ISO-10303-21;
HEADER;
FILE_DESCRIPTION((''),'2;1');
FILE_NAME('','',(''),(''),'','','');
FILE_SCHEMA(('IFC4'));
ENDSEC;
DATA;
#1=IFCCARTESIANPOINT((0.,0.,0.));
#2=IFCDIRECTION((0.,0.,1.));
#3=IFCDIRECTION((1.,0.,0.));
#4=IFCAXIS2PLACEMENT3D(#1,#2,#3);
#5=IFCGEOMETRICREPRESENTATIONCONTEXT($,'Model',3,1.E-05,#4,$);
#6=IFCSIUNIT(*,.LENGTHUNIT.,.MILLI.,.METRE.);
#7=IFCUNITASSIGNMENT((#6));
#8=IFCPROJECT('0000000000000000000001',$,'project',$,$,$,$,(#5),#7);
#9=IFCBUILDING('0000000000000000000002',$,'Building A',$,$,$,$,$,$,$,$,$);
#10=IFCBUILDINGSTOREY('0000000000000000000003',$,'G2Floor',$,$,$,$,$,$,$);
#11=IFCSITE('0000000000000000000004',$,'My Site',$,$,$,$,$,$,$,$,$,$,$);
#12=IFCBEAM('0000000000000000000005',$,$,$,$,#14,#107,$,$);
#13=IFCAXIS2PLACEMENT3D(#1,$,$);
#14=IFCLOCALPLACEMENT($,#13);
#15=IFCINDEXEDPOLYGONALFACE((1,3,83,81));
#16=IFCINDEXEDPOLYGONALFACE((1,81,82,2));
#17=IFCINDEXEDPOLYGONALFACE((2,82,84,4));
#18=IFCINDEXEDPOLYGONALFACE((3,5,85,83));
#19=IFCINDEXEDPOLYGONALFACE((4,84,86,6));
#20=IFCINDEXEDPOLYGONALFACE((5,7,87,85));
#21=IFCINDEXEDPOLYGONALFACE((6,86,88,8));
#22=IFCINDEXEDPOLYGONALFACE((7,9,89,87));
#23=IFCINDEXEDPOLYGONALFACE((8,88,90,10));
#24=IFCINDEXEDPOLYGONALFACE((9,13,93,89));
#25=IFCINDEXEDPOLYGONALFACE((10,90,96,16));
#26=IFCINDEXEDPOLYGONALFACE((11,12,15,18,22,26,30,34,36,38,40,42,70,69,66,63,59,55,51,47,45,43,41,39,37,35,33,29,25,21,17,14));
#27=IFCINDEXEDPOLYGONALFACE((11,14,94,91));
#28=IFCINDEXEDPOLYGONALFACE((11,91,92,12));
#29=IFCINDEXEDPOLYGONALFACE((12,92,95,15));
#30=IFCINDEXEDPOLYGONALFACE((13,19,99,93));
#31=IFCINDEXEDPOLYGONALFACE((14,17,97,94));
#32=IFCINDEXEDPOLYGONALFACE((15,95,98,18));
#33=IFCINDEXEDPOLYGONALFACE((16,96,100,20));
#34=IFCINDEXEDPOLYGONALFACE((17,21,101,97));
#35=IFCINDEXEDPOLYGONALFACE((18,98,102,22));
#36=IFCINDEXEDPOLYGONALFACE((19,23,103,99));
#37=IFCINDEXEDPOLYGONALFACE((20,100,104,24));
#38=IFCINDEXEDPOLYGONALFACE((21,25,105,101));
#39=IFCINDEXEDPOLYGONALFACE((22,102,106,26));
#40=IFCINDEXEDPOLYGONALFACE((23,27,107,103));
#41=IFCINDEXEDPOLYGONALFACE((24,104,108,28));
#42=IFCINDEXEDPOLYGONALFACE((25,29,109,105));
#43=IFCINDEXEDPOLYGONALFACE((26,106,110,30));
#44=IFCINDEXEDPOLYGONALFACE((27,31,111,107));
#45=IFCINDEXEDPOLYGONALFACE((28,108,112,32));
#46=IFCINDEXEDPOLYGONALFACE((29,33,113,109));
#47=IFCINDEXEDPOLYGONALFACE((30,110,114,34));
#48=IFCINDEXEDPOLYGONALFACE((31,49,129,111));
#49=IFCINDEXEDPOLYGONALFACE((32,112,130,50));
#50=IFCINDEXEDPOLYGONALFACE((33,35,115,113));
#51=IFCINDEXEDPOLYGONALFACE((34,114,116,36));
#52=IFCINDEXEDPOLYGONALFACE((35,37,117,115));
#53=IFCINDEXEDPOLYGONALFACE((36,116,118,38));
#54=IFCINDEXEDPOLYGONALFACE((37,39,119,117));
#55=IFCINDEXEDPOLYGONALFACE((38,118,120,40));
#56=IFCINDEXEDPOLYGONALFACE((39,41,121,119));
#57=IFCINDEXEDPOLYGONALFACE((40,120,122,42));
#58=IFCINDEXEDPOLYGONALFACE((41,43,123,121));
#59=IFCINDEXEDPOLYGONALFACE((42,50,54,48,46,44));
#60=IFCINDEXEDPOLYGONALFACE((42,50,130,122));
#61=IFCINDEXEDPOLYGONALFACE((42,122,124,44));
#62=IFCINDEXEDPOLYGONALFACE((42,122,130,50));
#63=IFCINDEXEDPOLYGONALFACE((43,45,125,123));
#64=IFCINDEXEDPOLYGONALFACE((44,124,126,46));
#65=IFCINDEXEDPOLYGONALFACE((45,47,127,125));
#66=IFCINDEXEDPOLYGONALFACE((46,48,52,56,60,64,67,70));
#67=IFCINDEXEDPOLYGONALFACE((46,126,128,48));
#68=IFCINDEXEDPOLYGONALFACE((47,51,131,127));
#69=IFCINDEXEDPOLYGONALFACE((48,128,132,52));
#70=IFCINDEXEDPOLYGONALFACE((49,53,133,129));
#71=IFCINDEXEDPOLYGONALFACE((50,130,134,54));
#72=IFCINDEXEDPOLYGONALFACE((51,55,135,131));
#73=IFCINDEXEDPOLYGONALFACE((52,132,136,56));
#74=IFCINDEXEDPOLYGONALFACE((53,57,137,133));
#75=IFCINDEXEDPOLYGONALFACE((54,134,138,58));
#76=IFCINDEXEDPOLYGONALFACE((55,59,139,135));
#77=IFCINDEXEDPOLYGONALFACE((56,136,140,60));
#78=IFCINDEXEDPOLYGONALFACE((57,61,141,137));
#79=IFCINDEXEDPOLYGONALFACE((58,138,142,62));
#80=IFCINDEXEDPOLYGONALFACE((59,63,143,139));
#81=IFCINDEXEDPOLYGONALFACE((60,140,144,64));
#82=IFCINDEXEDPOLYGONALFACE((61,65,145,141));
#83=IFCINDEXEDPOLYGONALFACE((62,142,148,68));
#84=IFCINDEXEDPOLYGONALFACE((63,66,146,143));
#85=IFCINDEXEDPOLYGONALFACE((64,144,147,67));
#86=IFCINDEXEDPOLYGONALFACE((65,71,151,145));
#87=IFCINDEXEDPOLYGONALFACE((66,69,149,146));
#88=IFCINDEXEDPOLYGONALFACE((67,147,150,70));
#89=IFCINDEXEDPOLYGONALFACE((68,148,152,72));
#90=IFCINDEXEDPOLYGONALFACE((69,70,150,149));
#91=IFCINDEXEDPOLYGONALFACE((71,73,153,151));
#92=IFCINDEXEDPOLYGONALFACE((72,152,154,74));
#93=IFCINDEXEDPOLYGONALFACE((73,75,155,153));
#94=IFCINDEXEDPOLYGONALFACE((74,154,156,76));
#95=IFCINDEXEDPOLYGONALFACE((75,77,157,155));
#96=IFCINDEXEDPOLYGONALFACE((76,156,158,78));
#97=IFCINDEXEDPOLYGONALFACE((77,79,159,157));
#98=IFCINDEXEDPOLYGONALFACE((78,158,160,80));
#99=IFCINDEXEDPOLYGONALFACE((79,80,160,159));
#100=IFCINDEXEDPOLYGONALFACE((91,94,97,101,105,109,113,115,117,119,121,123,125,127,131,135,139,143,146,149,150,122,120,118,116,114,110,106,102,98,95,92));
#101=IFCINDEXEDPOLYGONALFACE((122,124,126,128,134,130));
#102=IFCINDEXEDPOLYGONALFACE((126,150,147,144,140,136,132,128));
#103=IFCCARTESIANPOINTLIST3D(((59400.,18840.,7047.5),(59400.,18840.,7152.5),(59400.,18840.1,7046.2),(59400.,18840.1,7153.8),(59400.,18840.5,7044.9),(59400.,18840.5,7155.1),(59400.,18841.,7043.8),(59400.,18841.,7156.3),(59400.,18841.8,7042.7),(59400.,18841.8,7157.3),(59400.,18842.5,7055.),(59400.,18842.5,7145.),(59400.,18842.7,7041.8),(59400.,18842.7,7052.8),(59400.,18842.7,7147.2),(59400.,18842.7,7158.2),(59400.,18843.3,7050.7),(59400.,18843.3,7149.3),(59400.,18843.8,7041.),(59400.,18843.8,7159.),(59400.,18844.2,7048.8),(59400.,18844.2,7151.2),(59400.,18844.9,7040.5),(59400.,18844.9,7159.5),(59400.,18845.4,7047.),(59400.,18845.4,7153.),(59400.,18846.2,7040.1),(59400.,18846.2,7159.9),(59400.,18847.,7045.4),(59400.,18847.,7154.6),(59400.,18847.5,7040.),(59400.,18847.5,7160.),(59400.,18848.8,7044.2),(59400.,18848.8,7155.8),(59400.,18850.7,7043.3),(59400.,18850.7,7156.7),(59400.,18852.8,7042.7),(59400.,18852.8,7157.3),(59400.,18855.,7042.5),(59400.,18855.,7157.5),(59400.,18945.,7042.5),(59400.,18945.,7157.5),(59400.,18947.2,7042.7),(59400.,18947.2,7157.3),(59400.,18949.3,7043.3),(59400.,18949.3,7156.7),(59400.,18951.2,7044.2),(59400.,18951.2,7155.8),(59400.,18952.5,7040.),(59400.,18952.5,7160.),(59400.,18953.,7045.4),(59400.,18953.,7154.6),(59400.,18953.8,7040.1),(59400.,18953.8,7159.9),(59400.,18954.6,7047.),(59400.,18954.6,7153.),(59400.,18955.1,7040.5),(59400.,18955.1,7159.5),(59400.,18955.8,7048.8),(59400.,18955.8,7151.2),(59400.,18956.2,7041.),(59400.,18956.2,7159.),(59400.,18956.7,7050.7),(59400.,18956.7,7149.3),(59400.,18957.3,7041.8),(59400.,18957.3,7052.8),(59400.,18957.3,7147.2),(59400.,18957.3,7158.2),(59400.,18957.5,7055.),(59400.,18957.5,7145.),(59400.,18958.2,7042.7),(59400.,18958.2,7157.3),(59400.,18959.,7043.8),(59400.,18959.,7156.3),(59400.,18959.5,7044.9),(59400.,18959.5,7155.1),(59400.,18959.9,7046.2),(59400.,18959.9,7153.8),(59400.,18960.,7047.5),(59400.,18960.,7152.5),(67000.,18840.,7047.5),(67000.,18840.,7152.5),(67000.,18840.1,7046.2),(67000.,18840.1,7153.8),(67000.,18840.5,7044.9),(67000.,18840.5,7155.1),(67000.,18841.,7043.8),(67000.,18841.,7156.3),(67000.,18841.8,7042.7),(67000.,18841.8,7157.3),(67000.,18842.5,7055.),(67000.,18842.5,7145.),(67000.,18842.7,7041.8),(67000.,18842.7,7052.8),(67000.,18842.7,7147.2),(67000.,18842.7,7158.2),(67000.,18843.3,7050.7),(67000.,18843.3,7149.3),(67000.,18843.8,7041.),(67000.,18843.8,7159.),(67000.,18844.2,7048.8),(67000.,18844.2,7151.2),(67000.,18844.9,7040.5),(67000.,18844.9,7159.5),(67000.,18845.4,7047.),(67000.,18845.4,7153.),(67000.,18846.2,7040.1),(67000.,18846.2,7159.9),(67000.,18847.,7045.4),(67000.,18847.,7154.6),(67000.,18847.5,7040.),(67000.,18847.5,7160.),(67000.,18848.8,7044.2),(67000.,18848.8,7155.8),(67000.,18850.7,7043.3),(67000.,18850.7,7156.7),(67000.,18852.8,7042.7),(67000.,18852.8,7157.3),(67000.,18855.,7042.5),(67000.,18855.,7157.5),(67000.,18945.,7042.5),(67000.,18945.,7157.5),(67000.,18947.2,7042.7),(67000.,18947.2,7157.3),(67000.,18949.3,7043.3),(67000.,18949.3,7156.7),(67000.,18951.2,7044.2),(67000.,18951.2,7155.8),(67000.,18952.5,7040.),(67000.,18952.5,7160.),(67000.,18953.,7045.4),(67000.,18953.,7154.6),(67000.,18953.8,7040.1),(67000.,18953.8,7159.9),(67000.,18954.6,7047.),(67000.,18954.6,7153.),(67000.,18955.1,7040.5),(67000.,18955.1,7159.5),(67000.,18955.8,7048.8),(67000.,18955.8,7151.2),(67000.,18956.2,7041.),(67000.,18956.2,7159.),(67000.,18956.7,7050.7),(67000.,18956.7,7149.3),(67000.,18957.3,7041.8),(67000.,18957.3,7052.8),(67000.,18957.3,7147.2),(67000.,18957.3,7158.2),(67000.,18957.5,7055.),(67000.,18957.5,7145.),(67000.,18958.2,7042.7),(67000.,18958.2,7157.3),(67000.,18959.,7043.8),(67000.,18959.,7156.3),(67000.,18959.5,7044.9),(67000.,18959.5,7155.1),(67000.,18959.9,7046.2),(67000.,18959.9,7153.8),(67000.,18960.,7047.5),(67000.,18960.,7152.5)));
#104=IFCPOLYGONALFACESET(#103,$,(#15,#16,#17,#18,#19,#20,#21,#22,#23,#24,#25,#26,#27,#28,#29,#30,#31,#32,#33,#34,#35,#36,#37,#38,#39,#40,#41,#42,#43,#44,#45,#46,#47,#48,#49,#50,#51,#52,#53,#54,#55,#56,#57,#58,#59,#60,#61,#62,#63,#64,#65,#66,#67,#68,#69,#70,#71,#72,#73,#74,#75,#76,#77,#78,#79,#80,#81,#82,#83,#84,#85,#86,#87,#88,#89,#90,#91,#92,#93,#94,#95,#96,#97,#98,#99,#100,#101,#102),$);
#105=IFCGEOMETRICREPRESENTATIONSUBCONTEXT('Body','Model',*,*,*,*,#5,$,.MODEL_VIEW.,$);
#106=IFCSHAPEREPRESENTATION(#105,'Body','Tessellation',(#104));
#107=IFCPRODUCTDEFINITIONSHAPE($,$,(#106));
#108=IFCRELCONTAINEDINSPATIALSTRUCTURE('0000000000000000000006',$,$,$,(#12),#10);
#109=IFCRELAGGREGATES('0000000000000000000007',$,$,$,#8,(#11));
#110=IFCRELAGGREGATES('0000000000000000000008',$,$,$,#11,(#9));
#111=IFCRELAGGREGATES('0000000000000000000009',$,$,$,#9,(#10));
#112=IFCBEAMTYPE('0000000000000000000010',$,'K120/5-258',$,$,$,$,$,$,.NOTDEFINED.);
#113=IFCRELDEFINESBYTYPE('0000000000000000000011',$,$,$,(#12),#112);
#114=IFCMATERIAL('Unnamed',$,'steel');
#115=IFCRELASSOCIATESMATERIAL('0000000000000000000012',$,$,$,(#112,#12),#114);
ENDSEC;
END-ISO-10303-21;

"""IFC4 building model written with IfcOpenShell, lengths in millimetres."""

from ifc_helpers import new_model, si_unit, frame, origin_with_axes, place, context, subcontext, project, spatial, polyline, outline, extrude, material, material_profile, profile_set, profile_usage, type_object, element, save


model = new_model("IFC4")

# Units and contexts
model_context = context("Model", 3, precision=1e-05, world=origin_with_axes())
body_context = subcontext(model_context, "Body", "Model", "MODEL_VIEW")
ifc_project = project(units=[si_unit("LENGTHUNIT", "METRE", prefix="MILLI")], contexts=[model_context])

# Site, building, storey
site = spatial("IfcSite", under=ifc_project, Name="My Site")
building = spatial("IfcBuilding", under=site, Name="Building A")
storey = spatial("IfcBuildingStorey", under=building, Name="G2Floor")

# Beam
ifc_material_1 = material(Name="Unnamed", Category="steel")
ifc_material_profile_1 = material_profile(ifc_material_1, outline(polyline([(-52.5, -60.0), (52.5, -60.0), (52.5, -60.0), (53.8, -59.9), (53.8, -59.9), (55.1, -59.5), (55.1, -59.5), (56.2, -59.0), (56.2, -59.0), (57.3, -58.2), (57.3, -58.2), (58.2, -57.3), (58.2, -57.3), (59.0, -56.2), (59.0, -56.2), (59.5, -55.1), (59.5, -55.1), (59.9, -53.8), (59.9, -53.8), (60.0, -52.5), (60.0, -52.5), (60.0, 52.5), (60.0, 52.5), (59.9, 53.8), (59.9, 53.8), (59.5, 55.1), (59.5, 55.1), (59.0, 56.2), (59.0, 56.2), (58.2, 57.3), (58.2, 57.3), (57.3, 58.2), (57.3, 58.2), (56.2, 59.0), (56.2, 59.0), (55.1, 59.5), (55.1, 59.5), (53.8, 59.9), (53.8, 59.9), (52.5, 60.0), (52.5, 60.0), (-52.5, 60.0), (-52.5, 60.0), (-53.8, 59.9), (-53.8, 59.9), (-55.1, 59.5), (-55.1, 59.5), (-56.2, 59.0), (-56.2, 59.0), (-57.3, 58.2), (-57.3, 58.2), (-58.2, 57.3), (-58.2, 57.3), (-59.0, 56.2), (-59.0, 56.2), (-59.5, 55.1), (-59.5, 55.1), (-59.9, 53.8), (-59.9, 53.8), (-60.0, 52.5), (-60.0, 52.5), (-60.0, -52.5), (-60.0, -52.5), (-59.9, -53.8), (-59.9, -53.8), (-59.5, -55.1), (-59.5, -55.1), (-59.0, -56.2), (-59.0, -56.2), (-58.2, -57.3), (-58.2, -57.3), (-57.3, -58.2), (-57.3, -58.2), (-56.2, -59.0), (-56.2, -59.0), (-55.1, -59.5), (-55.1, -59.5), (-53.8, -59.9), (-53.8, -59.9), (-52.5, -60.0), (-52.5, -60.0), (-45.0, -57.5), (-45.0, -57.5), (45.0, -57.5), (45.0, -57.5), (47.2, -57.3), (47.2, -57.3), (49.3, -56.7), (49.3, -56.7), (51.2, -55.8), (51.2, -55.8), (53.0, -54.6), (53.0, -54.6), (54.6, -53.0), (54.6, -53.0), (55.8, -51.2), (55.8, -51.2), (56.7, -49.3), (56.7, -49.3), (57.3, -47.2), (57.3, -47.2), (57.5, -45.0), (57.5, -45.0), (57.5, 45.0), (57.5, 45.0), (57.3, 47.2), (57.3, 47.2), (56.7, 49.3), (56.7, 49.3), (55.8, 51.2), (55.8, 51.2), (54.6, 53.0), (54.6, 53.0), (53.0, 54.6), (53.0, 54.6), (51.2, 55.8), (51.2, 55.8), (49.3, 56.7), (49.3, 56.7), (47.2, 57.3), (47.2, 57.3), (45.0, 57.5), (45.0, 57.5), (-45.0, 57.5), (-45.0, 57.5), (-47.2, 57.3), (-47.2, 57.3), (-49.3, 56.7), (-49.3, 56.7), (-51.2, 55.8), (-51.2, 55.8), (-53.0, 54.6), (-53.0, 54.6), (-54.6, 53.0), (-54.6, 53.0), (-55.8, 51.2), (-55.8, 51.2), (-56.7, 49.3), (-56.7, 49.3), (-57.3, 47.2), (-57.3, 47.2), (-57.5, 45.0), (-57.5, 45.0), (-57.5, -45.0), (-57.5, -45.0), (-57.3, -47.2), (-57.3, -47.2), (-56.7, -49.3), (-56.7, -49.3), (-55.8, -51.2), (-55.8, -51.2), (-54.6, -53.0), (-54.6, -53.0), (-53.0, -54.6), (-53.0, -54.6), (-51.2, -55.8), (-51.2, -55.8), (-49.3, -56.7), (-49.3, -56.7), (-47.2, -57.3), (-47.2, -57.3), (-45.0, -57.5), (-45.0, -57.5), (-52.5, -60.0)])))
ifc_profile_set_1 = profile_set([ifc_material_profile_1], Name="K120/5-258")
ifc_profile_usage_1 = profile_usage(ifc_profile_set_1)
beam_type_1 = type_object("IfcBeamType", Name="K120/5-258", PredefinedType="NOTDEFINED", material=ifc_profile_set_1)
beam_1_placement = place(None, frame((59400.0, 18900.0, 7100.0), z_axis=(1.0, 0.0, 0.0), x_axis=(0.0, -1.0, 0.0)))
element("IfcBeam", 1, at=beam_1_placement, inside=storey, type_object=beam_type_1, material=ifc_profile_usage_1, context=body_context, shape_type="SweptSolid", body=[
    extrude(outline(polyline([(-52.5, -60.0), (52.5, -60.0), (52.5, -60.0), (53.8, -59.9), (53.8, -59.9), (55.1, -59.5), (55.1, -59.5), (56.2, -59.0), (56.2, -59.0), (57.3, -58.2), (57.3, -58.2), (58.2, -57.3), (58.2, -57.3), (59.0, -56.2), (59.0, -56.2), (59.5, -55.1), (59.5, -55.1), (59.9, -53.8), (59.9, -53.8), (60.0, -52.5), (60.0, -52.5), (60.0, 52.5), (60.0, 52.5), (59.9, 53.8), (59.9, 53.8), (59.5, 55.1), (59.5, 55.1), (59.0, 56.2), (59.0, 56.2), (58.2, 57.3), (58.2, 57.3), (57.3, 58.2), (57.3, 58.2), (56.2, 59.0), (56.2, 59.0), (55.1, 59.5), (55.1, 59.5), (53.8, 59.9), (53.8, 59.9), (52.5, 60.0), (52.5, 60.0), (-52.5, 60.0), (-52.5, 60.0), (-53.8, 59.9), (-53.8, 59.9), (-55.1, 59.5), (-55.1, 59.5), (-56.2, 59.0), (-56.2, 59.0), (-57.3, 58.2), (-57.3, 58.2), (-58.2, 57.3), (-58.2, 57.3), (-59.0, 56.2), (-59.0, 56.2), (-59.5, 55.1), (-59.5, 55.1), (-59.9, 53.8), (-59.9, 53.8), (-60.0, 52.5), (-60.0, 52.5), (-60.0, -52.5), (-60.0, -52.5), (-59.9, -53.8), (-59.9, -53.8), (-59.5, -55.1), (-59.5, -55.1), (-59.0, -56.2), (-59.0, -56.2), (-58.2, -57.3), (-58.2, -57.3), (-57.3, -58.2), (-57.3, -58.2), (-56.2, -59.0), (-56.2, -59.0), (-55.1, -59.5), (-55.1, -59.5), (-53.8, -59.9), (-53.8, -59.9), (-52.5, -60.0), (-52.5, -60.0), (-45.0, -57.5), (-45.0, -57.5), (45.0, -57.5), (45.0, -57.5), (47.2, -57.3), (47.2, -57.3), (49.3, -56.7), (49.3, -56.7), (51.2, -55.8), (51.2, -55.8), (53.0, -54.6), (53.0, -54.6), (54.6, -53.0), (54.6, -53.0), (55.8, -51.2), (55.8, -51.2), (56.7, -49.3), (56.7, -49.3), (57.3, -47.2), (57.3, -47.2), (57.5, -45.0), (57.5, -45.0), (57.5, 45.0), (57.5, 45.0), (57.3, 47.2), (57.3, 47.2), (56.7, 49.3), (56.7, 49.3), (55.8, 51.2), (55.8, 51.2), (54.6, 53.0), (54.6, 53.0), (53.0, 54.6), (53.0, 54.6), (51.2, 55.8), (51.2, 55.8), (49.3, 56.7), (49.3, 56.7), (47.2, 57.3), (47.2, 57.3), (45.0, 57.5), (45.0, 57.5), (-45.0, 57.5), (-45.0, 57.5), (-47.2, 57.3), (-47.2, 57.3), (-49.3, 56.7), (-49.3, 56.7), (-51.2, 55.8), (-51.2, 55.8), (-53.0, 54.6), (-53.0, 54.6), (-54.6, 53.0), (-54.6, 53.0), (-55.8, 51.2), (-55.8, 51.2), (-56.7, 49.3), (-56.7, 49.3), (-57.3, 47.2), (-57.3, 47.2), (-57.5, 45.0), (-57.5, 45.0), (-57.5, -45.0), (-57.5, -45.0), (-57.3, -47.2), (-57.3, -47.2), (-56.7, -49.3), (-56.7, -49.3), (-55.8, -51.2), (-55.8, -51.2), (-54.6, -53.0), (-54.6, -53.0), (-53.0, -54.6), (-53.0, -54.6), (-51.2, -55.8), (-51.2, -55.8), (-49.3, -56.7), (-49.3, -56.7), (-47.2, -57.3), (-47.2, -57.3), (-45.0, -57.5), (-45.0, -57.5), (-52.5, -60.0)])), origin_with_axes(), (0.0, 0.0, 1.0), 7600.0),
])

save(model, "model.ifc")
